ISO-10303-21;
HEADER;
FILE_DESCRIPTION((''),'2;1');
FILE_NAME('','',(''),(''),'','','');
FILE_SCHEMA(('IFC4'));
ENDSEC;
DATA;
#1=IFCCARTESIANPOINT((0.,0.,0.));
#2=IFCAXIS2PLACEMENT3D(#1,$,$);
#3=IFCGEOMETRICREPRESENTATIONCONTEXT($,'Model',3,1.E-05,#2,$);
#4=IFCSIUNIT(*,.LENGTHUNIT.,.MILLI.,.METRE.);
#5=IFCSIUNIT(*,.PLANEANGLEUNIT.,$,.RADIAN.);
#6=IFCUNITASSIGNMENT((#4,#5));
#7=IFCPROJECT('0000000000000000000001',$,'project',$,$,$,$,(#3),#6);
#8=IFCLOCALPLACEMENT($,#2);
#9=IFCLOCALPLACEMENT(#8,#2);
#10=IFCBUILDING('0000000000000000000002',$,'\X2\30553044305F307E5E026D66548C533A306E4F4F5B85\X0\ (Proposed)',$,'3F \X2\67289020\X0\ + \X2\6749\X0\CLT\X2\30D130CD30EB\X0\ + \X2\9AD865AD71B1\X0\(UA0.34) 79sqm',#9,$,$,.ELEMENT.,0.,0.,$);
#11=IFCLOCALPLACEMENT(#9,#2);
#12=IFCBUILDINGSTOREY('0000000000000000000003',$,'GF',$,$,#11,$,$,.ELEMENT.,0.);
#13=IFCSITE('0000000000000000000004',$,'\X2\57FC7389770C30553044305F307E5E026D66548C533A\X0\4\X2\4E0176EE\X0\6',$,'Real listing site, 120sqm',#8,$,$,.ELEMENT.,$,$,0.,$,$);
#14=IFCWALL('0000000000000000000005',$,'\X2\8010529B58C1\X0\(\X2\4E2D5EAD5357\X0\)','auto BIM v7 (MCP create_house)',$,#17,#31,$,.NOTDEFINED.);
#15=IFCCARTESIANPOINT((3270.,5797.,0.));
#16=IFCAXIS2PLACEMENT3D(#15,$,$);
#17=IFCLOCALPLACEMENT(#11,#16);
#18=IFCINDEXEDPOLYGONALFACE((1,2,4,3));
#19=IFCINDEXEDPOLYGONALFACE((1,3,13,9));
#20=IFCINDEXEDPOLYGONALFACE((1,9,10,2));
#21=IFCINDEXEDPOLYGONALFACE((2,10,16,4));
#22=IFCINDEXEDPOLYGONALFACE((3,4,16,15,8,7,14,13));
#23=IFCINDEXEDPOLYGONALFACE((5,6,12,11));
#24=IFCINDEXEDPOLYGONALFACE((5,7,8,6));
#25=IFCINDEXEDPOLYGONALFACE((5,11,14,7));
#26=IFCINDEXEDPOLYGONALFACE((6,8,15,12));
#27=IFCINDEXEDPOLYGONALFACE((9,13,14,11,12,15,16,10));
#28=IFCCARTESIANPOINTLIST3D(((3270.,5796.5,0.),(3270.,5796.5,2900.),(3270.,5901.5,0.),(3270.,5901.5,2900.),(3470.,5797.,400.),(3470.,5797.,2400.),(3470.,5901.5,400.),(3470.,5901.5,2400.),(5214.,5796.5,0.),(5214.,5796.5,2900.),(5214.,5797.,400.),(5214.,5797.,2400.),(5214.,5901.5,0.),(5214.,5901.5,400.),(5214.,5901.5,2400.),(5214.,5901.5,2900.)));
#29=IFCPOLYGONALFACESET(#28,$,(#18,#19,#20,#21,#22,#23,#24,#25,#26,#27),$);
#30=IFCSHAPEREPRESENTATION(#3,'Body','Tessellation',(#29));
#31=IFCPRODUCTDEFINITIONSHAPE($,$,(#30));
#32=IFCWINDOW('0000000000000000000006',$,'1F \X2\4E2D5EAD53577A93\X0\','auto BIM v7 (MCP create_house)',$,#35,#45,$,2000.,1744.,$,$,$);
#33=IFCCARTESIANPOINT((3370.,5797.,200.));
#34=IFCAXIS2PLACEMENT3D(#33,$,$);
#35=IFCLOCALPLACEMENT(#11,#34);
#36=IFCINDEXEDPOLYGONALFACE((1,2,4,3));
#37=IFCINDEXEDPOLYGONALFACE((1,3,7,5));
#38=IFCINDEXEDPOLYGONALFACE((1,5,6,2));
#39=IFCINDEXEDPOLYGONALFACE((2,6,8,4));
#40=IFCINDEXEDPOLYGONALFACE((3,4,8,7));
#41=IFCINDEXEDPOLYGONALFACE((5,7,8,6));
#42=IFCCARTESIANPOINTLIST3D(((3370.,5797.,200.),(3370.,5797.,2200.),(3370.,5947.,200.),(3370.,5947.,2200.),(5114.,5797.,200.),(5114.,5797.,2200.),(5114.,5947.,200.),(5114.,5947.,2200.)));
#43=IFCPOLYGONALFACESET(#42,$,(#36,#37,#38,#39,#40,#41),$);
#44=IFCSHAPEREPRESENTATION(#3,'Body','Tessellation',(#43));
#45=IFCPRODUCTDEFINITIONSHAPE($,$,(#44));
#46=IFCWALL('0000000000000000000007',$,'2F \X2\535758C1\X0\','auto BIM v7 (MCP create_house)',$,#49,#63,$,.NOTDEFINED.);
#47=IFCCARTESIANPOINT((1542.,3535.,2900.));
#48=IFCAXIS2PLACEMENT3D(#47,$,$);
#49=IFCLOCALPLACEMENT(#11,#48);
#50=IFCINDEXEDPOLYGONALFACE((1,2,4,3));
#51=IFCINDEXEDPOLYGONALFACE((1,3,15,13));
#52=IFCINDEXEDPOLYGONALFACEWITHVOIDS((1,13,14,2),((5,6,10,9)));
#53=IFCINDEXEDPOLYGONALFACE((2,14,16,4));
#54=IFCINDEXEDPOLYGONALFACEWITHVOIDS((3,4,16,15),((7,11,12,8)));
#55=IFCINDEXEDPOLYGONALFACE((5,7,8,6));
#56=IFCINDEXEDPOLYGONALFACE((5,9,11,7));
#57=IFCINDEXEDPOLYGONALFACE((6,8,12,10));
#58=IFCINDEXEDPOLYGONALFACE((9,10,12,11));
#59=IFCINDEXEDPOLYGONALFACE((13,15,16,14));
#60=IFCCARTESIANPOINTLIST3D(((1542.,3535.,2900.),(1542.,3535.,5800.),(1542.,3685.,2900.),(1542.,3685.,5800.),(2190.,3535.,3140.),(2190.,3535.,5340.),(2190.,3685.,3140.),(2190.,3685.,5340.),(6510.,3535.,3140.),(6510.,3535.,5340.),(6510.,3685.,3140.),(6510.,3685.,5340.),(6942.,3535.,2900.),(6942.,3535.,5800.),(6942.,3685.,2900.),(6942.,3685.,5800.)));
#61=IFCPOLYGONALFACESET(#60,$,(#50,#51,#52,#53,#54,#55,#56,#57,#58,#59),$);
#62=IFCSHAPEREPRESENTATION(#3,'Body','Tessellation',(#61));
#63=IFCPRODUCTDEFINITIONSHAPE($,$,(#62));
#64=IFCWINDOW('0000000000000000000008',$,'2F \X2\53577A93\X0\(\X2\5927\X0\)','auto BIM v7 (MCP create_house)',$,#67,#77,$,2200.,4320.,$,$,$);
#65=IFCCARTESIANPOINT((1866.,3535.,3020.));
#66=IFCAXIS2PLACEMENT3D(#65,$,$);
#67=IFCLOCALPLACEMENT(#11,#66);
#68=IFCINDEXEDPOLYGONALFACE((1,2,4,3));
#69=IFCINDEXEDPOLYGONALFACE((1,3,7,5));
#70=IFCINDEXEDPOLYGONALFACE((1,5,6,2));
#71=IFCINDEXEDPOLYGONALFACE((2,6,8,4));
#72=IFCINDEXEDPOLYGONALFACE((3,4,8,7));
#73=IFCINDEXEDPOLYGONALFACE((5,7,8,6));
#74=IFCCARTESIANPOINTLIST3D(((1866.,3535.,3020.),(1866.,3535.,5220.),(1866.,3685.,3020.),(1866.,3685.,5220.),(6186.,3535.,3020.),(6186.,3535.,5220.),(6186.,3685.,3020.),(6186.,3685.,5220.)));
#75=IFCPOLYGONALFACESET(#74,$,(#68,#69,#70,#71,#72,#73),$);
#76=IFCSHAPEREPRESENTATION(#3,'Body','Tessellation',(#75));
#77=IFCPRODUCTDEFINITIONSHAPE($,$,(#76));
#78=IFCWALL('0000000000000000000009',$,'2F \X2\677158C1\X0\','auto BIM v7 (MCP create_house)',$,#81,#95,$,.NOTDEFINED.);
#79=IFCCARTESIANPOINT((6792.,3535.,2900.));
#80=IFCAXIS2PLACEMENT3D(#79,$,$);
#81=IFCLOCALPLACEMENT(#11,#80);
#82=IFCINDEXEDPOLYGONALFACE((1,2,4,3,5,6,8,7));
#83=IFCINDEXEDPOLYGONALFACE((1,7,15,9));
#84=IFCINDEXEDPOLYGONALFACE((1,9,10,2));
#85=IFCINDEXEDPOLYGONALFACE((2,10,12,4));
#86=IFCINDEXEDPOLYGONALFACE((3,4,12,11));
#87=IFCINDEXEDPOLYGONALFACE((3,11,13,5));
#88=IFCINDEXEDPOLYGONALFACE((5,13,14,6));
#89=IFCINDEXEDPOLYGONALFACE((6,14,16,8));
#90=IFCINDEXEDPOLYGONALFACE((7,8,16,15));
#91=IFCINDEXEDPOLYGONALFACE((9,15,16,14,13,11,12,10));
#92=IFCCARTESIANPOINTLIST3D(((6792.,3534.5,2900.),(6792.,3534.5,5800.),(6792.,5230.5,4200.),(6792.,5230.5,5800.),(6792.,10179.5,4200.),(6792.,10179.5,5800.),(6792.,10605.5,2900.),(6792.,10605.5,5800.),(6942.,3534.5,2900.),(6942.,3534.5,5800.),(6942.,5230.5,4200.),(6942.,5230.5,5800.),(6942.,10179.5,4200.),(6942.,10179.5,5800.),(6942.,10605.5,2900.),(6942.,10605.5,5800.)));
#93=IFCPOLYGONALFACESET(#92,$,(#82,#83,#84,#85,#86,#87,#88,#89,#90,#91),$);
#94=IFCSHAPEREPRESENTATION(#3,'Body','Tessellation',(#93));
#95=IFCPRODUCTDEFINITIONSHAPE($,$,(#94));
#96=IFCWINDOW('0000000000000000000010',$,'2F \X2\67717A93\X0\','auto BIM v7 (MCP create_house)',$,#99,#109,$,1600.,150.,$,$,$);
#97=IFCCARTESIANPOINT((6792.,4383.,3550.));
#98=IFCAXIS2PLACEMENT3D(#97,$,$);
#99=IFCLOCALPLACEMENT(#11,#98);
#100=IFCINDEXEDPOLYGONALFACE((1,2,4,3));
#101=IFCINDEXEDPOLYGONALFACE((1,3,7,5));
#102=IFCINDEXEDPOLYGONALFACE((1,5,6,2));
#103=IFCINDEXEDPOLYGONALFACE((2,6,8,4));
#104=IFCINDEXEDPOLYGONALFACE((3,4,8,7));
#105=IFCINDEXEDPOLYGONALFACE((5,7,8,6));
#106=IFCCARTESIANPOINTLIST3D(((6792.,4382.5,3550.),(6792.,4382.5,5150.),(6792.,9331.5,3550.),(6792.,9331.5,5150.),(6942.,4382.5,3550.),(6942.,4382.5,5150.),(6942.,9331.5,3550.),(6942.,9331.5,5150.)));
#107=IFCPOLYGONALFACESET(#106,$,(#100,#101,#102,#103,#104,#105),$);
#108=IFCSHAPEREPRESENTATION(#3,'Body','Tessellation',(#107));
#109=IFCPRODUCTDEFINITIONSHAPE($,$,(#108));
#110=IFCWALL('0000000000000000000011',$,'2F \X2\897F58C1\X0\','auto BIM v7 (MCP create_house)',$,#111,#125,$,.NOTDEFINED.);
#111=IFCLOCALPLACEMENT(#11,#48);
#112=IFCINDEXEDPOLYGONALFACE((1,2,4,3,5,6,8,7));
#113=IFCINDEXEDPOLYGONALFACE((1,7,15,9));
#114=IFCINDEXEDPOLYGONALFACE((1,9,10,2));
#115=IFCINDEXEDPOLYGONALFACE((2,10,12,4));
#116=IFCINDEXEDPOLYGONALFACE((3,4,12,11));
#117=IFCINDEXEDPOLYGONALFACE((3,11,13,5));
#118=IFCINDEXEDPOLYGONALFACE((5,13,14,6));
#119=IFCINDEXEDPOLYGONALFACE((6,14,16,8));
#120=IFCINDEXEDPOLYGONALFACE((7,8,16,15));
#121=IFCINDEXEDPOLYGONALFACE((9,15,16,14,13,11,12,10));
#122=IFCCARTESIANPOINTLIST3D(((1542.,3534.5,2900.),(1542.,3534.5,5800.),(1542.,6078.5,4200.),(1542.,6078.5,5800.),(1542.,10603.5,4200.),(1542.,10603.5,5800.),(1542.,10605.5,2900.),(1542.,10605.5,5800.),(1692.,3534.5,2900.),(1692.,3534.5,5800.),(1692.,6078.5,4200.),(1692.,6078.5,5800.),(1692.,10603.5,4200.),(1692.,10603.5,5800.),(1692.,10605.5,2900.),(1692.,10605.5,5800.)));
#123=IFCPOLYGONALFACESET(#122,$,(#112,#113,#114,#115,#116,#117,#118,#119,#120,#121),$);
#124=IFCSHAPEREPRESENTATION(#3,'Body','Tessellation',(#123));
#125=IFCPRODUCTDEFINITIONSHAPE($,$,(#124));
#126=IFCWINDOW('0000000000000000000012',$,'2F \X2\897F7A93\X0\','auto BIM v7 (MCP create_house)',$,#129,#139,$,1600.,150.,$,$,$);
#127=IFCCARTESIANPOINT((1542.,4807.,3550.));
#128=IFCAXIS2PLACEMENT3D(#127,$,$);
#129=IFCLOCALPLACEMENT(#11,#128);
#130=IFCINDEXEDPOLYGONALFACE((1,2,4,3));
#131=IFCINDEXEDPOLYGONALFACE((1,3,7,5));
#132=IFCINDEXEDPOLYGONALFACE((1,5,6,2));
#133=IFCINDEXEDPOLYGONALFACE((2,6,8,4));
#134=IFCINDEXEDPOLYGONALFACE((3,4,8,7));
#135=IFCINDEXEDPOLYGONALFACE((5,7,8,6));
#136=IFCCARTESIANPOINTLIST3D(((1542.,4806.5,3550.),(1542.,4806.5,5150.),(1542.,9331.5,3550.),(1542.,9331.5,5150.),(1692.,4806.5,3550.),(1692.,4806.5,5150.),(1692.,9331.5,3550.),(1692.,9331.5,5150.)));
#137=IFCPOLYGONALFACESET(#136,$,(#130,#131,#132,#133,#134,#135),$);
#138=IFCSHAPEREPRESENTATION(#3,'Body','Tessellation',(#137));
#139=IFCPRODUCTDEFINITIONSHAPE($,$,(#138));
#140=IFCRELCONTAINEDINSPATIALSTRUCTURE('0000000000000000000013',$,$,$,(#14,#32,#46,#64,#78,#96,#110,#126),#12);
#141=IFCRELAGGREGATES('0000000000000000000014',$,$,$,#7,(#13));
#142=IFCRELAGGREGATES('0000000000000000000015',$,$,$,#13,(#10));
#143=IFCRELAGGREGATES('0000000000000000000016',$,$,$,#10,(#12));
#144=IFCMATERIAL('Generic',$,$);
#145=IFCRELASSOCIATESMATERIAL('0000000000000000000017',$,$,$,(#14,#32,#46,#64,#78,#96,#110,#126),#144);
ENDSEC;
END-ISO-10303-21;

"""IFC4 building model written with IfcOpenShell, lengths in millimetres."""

from ifc_helpers import new_model, si_unit, frame, frame_2d, origin, place, context, project, spatial, rectangle, extrude, material, element, fill, save


model = new_model("IFC4")

# Units and contexts
model_context = context("Model", 3, precision=1e-05, world=origin())
ifc_project = project(units=[si_unit("LENGTHUNIT", "METRE", prefix="MILLI"), si_unit("PLANEANGLEUNIT", "RADIAN")], contexts=[model_context])

# Site, building, storey
site_placement = place(None, origin())
site = spatial("IfcSite", under=ifc_project, at=site_placement, Name="埼玉県さいたま市浦和区4丁目6", ObjectType="Real listing site, 120sqm", CompositionType="ELEMENT", RefElevation=0.0)
building_placement = place(site_placement, origin())
building = spatial("IfcBuilding", under=site, at=building_placement, Name="さいたま市浦和区の住宅 (Proposed)", ObjectType="3F 木造 + 杉CLTパネル + 高断熱(UA0.34) 79sqm", CompositionType="ELEMENT", ElevationOfRefHeight=0.0, ElevationOfTerrain=0.0)
storey_placement = place(building_placement, origin())
storey = spatial("IfcBuildingStorey", under=building, at=storey_placement, Name="GF", CompositionType="ELEMENT", Elevation=0.0)

# Shared definitions
ifc_material = material(Name="Generic")

# Walls, openings, windows
wall_1_placement = place(storey_placement, frame((3270.0, 5797.0, 0.0)))
wall_1 = element("IfcWall", 1, at=wall_1_placement, inside=storey, material=ifc_material, Name="耐力壁(中庭南)", Description="auto BIM v7 (MCP create_house)", PredefinedType="NOTDEFINED", context=model_context, shape_type="SweptSolid", body=[
    extrude(rectangle(XDim=1944.0, YDim=105.0, at=frame_2d((972.0, 52.0))), frame((3270.0, 5797.0, 0.0)), (0.0, 0.0, 1.0), 2900.0),
])
opening_1_placement = place(storey_placement, frame((3370.0, 5797.0, 200.0)))
opening_1 = element("IfcOpeningElement", 2, at=opening_1_placement, cuts=wall_1, PredefinedType="NOTDEFINED", context=model_context, shape_type="SweptSolid", body=[
    extrude(rectangle(XDim=1744.0, YDim=150.0, at=frame_2d((872.0, 75.0))), frame((3370.0, 5797.0, 200.0)), (0.0, 0.0, 1.0), 2000.0),
])
window_1_placement = place(storey_placement, frame((3370.0, 5797.0, 200.0)))
window_1 = element("IfcWindow", 3, at=window_1_placement, inside=storey, material=ifc_material, Name="1F 中庭南窓", Description="auto BIM v7 (MCP create_house)", OverallHeight=2000.0, OverallWidth=1744.0, context=model_context, shape_type="SweptSolid", body=[
    extrude(rectangle(XDim=1744.0, YDim=150.0, at=frame_2d((872.0, 75.0))), frame((3370.0, 5797.0, 200.0)), (0.0, 0.0, 1.0), 2000.0),
])
fill(opening_1, window_1)
wall_2_placement = place(storey_placement, frame((1542.0, 3535.0, 2900.0)))
wall_2 = element("IfcWall", 4, at=wall_2_placement, inside=storey, material=ifc_material, Name="2F 南壁", Description="auto BIM v7 (MCP create_house)", PredefinedType="NOTDEFINED", context=model_context, shape_type="SweptSolid", body=[
    extrude(rectangle(XDim=5400.0, YDim=150.0, at=frame_2d((2700.0, 75.0))), frame((1542.0, 3535.0, 2900.0)), (0.0, 0.0, 1.0), 2900.0),
])
opening_2_placement = place(storey_placement, frame((1866.0, 3535.0, 3020.0)))
opening_2 = element("IfcOpeningElement", 5, at=opening_2_placement, cuts=wall_2, PredefinedType="NOTDEFINED", context=model_context, shape_type="SweptSolid", body=[
    extrude(rectangle(XDim=4320.0, YDim=150.0, at=frame_2d((2160.0, 75.0))), frame((1866.0, 3535.0, 3020.0)), (0.0, 0.0, 1.0), 2200.0),
])
window_2_placement = place(storey_placement, frame((1866.0, 3535.0, 3020.0)))
window_2 = element("IfcWindow", 6, at=window_2_placement, inside=storey, material=ifc_material, Name="2F 南窓(大)", Description="auto BIM v7 (MCP create_house)", OverallHeight=2200.0, OverallWidth=4320.0, context=model_context, shape_type="SweptSolid", body=[
    extrude(rectangle(XDim=4320.0, YDim=150.0, at=frame_2d((2160.0, 75.0))), frame((1866.0, 3535.0, 3020.0)), (0.0, 0.0, 1.0), 2200.0),
])
fill(opening_2, window_2)
wall_3_placement = place(storey_placement, frame((6792.0, 3535.0, 2900.0)))
wall_3 = element("IfcWall", 7, at=wall_3_placement, inside=storey, material=ifc_material, Name="2F 東壁", Description="auto BIM v7 (MCP create_house)", PredefinedType="NOTDEFINED", context=model_context, shape_type="SweptSolid", body=[
    extrude(rectangle(XDim=150.0, YDim=7071.0, at=frame_2d((75.0, 3535.0))), frame((6792.0, 3535.0, 2900.0)), (0.0, 0.0, 1.0), 2900.0),
])
opening_3_placement = place(storey_placement, frame((6792.0, 4383.0, 3550.0)))
opening_3 = element("IfcOpeningElement", 8, at=opening_3_placement, cuts=wall_3, PredefinedType="NOTDEFINED", context=model_context, shape_type="SweptSolid", body=[
    extrude(rectangle(XDim=150.0, YDim=4949.0, at=frame_2d((75.0, 2474.0))), frame((6792.0, 4383.0, 3550.0)), (0.0, 0.0, 1.0), 1600.0),
])
window_3_placement = place(storey_placement, frame((6792.0, 4383.0, 3550.0)))
window_3 = element("IfcWindow", 9, at=window_3_placement, inside=storey, material=ifc_material, Name="2F 東窓", Description="auto BIM v7 (MCP create_house)", OverallHeight=1600.0, OverallWidth=150.0, context=model_context, shape_type="SweptSolid", body=[
    extrude(rectangle(XDim=150.0, YDim=4949.0, at=frame_2d((75.0, 2474.0))), frame((6792.0, 4383.0, 3550.0)), (0.0, 0.0, 1.0), 1600.0),
])
fill(opening_3, window_3)
wall_4_placement = place(storey_placement, frame((1542.0, 3535.0, 2900.0)))
wall_4 = element("IfcWall", 10, at=wall_4_placement, inside=storey, material=ifc_material, Name="2F 西壁", Description="auto BIM v7 (MCP create_house)", PredefinedType="NOTDEFINED", context=model_context, shape_type="SweptSolid", body=[
    extrude(rectangle(XDim=150.0, YDim=7071.0, at=frame_2d((75.0, 3535.0))), frame((1542.0, 3535.0, 2900.0)), (0.0, 0.0, 1.0), 2900.0),
])
opening_4_placement = place(storey_placement, frame((1542.0, 4807.0, 3550.0)))
opening_4 = element("IfcOpeningElement", 11, at=opening_4_placement, cuts=wall_4, PredefinedType="NOTDEFINED", context=model_context, shape_type="SweptSolid", body=[
    extrude(rectangle(XDim=150.0, YDim=4525.0, at=frame_2d((75.0, 2262.0))), frame((1542.0, 4807.0, 3550.0)), (0.0, 0.0, 1.0), 1600.0),
])
window_4_placement = place(storey_placement, frame((1542.0, 4807.0, 3550.0)))
window_4 = element("IfcWindow", 12, at=window_4_placement, inside=storey, material=ifc_material, Name="2F 西窓", Description="auto BIM v7 (MCP create_house)", OverallHeight=1600.0, OverallWidth=150.0, context=model_context, shape_type="SweptSolid", body=[
    extrude(rectangle(XDim=150.0, YDim=4525.0, at=frame_2d((75.0, 2262.0))), frame((1542.0, 4807.0, 3550.0)), (0.0, 0.0, 1.0), 1600.0),
])
fill(opening_4, window_4)

save(model, "model.ifc")
